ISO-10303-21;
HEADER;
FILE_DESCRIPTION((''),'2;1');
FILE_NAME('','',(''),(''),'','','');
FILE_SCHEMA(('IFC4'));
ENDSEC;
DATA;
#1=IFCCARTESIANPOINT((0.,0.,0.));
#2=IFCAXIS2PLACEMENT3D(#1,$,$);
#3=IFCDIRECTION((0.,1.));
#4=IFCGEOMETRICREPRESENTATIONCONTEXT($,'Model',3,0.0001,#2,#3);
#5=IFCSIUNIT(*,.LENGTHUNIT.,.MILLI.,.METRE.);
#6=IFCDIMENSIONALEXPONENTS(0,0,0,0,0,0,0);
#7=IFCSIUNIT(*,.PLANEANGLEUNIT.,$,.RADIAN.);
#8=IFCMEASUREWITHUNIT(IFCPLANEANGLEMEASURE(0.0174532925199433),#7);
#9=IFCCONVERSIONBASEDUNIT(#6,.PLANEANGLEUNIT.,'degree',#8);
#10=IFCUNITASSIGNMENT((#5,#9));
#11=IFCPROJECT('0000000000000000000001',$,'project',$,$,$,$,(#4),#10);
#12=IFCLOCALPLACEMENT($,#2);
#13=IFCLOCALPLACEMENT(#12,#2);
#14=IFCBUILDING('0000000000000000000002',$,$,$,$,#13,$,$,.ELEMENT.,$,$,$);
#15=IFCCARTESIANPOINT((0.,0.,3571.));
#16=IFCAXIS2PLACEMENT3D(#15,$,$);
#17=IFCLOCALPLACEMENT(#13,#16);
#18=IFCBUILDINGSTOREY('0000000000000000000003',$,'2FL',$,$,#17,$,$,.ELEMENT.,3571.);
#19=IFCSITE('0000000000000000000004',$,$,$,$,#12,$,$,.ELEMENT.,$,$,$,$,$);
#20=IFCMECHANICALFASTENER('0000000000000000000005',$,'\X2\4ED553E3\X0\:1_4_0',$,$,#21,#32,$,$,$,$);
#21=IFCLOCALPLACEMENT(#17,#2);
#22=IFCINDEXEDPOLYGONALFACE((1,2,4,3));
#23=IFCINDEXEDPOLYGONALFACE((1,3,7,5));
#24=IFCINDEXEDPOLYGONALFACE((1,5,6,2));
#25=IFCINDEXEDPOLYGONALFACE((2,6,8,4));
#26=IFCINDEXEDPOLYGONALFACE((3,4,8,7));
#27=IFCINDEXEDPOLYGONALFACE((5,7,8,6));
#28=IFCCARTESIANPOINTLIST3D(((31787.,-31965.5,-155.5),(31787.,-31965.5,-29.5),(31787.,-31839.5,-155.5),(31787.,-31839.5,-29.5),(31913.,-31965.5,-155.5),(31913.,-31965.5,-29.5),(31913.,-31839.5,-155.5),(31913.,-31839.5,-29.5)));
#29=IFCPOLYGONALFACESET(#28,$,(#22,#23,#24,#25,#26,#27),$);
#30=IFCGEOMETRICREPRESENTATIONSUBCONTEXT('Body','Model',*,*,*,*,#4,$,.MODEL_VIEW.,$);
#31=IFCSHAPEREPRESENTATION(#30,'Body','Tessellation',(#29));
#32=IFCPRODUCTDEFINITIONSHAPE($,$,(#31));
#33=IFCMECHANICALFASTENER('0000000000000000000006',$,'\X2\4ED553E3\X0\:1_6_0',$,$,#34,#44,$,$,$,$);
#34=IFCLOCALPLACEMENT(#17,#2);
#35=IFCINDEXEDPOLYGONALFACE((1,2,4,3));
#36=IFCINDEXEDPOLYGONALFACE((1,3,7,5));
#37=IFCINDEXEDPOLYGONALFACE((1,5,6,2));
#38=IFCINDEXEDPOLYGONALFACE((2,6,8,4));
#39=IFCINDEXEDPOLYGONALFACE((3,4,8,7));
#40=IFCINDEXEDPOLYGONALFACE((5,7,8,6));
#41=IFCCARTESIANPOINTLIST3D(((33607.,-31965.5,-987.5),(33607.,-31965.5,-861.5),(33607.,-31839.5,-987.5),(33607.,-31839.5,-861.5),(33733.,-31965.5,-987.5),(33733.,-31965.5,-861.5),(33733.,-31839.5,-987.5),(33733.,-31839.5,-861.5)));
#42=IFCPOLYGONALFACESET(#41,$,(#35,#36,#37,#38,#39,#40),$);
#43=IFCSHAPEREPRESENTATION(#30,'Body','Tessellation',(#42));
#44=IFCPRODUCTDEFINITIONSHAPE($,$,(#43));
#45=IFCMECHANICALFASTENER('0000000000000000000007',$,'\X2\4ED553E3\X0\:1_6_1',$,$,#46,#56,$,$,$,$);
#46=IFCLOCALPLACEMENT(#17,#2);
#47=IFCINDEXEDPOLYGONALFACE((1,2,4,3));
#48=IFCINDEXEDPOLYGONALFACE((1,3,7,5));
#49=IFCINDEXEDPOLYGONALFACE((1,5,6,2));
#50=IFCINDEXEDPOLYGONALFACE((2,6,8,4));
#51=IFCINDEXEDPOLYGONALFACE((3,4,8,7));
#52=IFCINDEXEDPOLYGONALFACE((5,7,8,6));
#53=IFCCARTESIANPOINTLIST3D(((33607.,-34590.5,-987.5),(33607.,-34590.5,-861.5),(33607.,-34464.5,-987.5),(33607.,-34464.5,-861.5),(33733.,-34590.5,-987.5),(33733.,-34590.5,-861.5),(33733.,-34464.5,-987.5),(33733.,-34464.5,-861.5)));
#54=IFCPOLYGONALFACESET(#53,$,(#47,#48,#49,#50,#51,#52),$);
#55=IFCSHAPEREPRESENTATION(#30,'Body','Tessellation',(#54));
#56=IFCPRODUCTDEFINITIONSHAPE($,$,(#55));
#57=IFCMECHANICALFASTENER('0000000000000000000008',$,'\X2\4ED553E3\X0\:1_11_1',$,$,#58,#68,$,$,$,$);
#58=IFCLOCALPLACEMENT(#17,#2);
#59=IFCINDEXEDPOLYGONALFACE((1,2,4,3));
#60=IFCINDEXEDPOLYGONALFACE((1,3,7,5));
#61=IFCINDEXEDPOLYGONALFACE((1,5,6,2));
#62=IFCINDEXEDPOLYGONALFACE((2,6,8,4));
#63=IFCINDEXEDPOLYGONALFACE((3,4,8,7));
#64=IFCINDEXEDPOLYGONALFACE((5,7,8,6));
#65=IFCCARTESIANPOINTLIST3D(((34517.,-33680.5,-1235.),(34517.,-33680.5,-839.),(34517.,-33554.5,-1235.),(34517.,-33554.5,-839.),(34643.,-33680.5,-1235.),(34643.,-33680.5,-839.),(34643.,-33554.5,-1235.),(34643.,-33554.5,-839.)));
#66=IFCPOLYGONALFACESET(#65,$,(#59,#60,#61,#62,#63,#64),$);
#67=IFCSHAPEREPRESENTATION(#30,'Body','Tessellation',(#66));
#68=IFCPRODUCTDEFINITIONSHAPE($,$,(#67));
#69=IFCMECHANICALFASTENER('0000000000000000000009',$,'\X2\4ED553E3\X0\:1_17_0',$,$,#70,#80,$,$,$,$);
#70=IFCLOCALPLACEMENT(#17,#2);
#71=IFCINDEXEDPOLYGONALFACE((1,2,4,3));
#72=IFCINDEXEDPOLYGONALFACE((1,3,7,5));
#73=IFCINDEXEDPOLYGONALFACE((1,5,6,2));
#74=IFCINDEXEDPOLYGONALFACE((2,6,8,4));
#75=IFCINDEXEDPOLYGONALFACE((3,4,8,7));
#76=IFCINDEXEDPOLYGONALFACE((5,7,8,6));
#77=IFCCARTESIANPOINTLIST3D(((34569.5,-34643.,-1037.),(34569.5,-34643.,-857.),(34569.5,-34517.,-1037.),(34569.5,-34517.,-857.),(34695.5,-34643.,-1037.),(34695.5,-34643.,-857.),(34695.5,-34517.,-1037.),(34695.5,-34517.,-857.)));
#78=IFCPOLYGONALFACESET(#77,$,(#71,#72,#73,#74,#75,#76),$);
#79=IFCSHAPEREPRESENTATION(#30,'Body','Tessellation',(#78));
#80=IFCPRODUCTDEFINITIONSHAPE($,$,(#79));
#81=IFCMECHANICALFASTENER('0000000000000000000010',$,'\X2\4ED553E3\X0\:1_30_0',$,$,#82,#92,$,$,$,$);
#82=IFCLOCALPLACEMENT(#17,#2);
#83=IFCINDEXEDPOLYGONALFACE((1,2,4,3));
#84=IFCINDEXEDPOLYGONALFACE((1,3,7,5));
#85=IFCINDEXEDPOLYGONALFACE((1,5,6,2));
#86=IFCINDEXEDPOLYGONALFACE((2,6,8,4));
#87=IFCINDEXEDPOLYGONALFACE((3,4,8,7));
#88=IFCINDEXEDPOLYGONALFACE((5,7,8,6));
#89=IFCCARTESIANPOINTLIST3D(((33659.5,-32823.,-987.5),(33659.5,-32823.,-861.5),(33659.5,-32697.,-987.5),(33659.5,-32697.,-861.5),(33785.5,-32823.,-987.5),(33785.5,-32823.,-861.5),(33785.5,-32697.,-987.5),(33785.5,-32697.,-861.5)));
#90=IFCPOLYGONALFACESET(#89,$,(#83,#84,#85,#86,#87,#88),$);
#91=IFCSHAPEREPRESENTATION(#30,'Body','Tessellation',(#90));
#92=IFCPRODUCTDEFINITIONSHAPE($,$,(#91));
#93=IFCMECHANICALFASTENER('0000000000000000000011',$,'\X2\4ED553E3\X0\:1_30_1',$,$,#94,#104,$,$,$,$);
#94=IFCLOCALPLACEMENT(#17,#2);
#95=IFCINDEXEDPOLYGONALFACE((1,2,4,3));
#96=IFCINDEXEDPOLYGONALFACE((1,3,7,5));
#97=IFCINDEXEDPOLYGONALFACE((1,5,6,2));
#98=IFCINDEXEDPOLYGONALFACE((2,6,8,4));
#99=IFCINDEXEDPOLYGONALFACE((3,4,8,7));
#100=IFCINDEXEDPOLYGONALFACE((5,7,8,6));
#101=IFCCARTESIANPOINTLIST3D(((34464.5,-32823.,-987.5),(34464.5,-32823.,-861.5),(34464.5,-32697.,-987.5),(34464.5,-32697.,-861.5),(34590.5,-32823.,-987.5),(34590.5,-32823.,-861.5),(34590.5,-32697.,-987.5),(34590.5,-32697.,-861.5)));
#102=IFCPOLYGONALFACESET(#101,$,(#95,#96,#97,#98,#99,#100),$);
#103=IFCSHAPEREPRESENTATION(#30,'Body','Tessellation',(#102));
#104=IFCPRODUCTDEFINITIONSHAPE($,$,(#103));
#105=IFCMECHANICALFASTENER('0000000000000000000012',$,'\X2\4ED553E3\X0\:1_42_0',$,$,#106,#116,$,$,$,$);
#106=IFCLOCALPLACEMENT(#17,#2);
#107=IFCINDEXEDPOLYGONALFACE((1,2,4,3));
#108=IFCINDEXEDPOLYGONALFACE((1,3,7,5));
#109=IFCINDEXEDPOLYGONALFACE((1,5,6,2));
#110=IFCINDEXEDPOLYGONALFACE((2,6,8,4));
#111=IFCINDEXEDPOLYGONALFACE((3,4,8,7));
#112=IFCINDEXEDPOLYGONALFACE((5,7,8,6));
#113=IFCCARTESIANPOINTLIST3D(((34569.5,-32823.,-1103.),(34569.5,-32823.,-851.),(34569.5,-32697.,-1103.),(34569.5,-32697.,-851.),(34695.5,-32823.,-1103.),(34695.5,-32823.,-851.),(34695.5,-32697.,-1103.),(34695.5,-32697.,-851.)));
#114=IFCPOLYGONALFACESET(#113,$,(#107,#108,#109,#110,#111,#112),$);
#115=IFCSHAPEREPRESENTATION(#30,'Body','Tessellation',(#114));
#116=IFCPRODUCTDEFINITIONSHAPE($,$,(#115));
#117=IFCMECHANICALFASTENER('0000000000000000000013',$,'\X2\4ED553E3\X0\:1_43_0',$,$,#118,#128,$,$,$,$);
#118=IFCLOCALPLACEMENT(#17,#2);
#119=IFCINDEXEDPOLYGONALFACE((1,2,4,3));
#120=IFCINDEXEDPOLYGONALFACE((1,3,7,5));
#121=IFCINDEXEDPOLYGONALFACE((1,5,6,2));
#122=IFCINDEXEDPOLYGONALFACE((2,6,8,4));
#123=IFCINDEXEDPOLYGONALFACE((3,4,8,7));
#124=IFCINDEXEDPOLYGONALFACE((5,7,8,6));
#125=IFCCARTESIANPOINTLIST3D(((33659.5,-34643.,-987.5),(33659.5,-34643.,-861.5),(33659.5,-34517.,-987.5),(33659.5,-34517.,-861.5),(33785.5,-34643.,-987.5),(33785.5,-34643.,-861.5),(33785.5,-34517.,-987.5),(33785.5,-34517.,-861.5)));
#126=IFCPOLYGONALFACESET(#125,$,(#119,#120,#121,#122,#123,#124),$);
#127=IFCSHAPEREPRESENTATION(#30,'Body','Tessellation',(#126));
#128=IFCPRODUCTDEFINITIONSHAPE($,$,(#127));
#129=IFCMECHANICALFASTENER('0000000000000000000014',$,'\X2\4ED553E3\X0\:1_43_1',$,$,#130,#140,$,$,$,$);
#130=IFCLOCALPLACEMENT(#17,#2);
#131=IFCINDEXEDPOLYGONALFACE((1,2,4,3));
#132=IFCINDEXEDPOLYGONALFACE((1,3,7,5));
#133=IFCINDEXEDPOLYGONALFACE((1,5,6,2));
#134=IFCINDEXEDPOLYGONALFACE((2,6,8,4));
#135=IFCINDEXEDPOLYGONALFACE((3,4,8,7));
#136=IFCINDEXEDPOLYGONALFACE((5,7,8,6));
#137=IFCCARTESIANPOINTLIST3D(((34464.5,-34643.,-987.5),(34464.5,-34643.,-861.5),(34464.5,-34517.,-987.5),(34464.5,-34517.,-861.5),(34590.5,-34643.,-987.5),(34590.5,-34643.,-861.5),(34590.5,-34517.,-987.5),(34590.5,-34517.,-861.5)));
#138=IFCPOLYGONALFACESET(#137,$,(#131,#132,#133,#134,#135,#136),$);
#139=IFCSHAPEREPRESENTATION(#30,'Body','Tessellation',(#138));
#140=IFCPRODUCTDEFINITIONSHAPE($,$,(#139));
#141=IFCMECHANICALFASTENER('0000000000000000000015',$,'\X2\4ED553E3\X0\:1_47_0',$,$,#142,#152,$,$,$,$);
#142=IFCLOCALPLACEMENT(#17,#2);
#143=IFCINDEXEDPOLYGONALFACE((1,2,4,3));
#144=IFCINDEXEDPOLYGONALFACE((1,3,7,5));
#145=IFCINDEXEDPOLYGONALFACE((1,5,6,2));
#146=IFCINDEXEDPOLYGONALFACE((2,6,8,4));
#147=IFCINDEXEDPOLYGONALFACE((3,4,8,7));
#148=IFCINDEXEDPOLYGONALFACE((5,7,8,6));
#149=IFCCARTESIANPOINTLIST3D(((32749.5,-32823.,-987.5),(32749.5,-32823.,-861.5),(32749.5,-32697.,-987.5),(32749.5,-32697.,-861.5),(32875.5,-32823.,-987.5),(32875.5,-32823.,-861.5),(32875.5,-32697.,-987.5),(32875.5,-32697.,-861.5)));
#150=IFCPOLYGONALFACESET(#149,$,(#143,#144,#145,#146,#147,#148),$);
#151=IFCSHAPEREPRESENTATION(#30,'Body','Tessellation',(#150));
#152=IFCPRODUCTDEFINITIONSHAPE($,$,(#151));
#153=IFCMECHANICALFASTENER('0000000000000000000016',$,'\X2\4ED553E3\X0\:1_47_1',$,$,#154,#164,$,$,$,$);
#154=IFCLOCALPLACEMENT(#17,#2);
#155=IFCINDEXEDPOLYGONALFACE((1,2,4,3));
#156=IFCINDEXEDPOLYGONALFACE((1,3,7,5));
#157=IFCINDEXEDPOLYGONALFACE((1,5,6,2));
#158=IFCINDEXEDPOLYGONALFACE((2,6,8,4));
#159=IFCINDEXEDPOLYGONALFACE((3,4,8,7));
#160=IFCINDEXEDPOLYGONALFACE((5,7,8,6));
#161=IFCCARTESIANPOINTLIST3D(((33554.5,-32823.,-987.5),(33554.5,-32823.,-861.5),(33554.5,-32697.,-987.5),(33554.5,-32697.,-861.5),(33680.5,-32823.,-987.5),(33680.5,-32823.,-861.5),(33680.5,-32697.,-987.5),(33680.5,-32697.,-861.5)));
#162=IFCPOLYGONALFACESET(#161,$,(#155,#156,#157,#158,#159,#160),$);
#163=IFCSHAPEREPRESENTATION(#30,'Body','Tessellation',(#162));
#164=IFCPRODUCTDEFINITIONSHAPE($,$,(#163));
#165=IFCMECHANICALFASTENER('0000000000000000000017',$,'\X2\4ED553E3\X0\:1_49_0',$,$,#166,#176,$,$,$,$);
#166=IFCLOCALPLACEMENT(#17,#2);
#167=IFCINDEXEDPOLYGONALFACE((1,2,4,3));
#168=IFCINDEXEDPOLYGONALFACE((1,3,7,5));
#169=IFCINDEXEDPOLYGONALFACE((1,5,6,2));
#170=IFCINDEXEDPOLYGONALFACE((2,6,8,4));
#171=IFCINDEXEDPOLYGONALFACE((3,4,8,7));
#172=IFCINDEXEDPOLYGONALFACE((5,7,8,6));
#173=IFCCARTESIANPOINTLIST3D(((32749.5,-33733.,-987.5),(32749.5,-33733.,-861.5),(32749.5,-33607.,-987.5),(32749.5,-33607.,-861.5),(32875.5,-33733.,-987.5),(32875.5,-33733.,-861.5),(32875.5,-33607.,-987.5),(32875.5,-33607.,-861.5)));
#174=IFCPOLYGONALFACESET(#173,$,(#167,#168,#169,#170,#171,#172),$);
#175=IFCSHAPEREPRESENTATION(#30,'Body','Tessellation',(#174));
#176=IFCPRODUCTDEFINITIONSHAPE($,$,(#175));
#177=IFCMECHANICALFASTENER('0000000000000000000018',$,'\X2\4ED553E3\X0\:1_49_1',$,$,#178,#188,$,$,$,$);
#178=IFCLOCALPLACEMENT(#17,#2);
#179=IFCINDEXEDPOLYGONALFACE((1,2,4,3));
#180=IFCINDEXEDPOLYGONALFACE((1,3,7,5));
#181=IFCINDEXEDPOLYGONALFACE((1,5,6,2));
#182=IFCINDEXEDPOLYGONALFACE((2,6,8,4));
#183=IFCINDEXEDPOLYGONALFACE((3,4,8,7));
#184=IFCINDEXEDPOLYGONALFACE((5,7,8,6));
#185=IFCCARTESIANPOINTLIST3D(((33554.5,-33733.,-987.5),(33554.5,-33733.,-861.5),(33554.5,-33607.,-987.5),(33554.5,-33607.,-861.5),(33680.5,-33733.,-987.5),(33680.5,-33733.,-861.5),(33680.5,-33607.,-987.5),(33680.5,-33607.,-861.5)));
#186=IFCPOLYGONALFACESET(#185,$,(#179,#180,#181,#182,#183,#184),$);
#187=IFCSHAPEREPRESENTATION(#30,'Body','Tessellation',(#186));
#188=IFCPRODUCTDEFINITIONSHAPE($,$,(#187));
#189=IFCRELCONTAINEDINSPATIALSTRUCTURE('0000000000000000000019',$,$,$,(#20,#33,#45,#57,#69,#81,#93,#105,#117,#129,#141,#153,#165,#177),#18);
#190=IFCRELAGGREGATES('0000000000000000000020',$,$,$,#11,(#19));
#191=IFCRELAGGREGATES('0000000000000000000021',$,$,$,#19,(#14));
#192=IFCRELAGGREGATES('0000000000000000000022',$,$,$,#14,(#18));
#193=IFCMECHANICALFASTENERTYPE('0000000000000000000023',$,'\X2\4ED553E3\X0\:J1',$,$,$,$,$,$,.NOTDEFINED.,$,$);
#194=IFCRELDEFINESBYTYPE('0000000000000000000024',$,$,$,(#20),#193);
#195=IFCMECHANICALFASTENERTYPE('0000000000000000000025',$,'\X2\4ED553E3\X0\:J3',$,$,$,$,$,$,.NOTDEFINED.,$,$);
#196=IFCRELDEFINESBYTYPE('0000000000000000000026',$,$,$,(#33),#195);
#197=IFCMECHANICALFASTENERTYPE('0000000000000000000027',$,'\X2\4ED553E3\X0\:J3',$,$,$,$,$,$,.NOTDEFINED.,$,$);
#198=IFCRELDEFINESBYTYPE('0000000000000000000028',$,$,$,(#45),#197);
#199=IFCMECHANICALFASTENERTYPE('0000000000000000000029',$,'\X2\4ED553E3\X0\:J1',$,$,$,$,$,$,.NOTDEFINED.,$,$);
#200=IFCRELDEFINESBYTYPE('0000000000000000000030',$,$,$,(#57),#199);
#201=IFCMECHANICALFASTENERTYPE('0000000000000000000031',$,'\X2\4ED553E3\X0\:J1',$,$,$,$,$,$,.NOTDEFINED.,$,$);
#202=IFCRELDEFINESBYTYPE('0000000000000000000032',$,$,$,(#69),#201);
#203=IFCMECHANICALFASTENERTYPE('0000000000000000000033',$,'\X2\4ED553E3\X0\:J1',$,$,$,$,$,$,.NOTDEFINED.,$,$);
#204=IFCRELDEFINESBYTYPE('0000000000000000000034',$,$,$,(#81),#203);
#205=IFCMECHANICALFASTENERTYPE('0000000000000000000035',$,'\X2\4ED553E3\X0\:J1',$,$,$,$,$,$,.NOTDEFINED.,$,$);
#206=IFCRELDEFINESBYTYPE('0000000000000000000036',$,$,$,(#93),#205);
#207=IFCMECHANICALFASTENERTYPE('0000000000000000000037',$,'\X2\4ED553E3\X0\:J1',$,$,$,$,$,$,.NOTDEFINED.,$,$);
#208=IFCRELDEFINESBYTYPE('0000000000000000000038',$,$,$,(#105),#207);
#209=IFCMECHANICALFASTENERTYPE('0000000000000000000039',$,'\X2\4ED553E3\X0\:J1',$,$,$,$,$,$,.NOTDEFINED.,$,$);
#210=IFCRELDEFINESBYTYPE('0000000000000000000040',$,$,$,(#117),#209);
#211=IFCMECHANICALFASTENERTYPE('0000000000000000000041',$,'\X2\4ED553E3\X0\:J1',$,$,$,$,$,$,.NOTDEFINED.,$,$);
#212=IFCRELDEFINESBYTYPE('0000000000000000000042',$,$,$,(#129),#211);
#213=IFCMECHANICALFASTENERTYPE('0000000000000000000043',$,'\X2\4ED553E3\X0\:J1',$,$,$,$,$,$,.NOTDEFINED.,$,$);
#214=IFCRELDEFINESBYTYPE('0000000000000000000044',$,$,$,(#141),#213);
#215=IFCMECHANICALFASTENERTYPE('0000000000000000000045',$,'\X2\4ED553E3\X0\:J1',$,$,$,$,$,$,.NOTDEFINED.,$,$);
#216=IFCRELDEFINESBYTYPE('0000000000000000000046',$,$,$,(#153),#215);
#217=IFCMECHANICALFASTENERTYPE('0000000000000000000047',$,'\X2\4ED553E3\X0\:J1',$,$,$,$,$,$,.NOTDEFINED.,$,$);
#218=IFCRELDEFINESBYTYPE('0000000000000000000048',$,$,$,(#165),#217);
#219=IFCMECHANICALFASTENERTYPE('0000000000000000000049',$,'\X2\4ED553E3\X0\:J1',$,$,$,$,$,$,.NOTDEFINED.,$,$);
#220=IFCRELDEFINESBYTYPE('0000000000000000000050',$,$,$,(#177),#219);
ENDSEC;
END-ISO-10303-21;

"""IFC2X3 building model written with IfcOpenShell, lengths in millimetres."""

from ifc_helpers import new_model, entity, si_unit, converted_unit, direction, frame, origin, origin_with_axes, origin_2d, place, context, subcontext, project, spatial, rectangle, extrude, type_object, element, save


model = new_model("IFC2X3")

# Units and contexts
model_context = context("Model", 3, precision=0.0001, world=origin(), true_north=direction((0.0, 1.0)))
body_context = subcontext(model_context, "Body", "Model", "MODEL_VIEW")
ifc_project = project(units=[si_unit("LENGTHUNIT", "METRE", prefix="MILLI"), converted_unit("PLANEANGLEUNIT", "degree", entity("IfcPlaneAngleMeasure", 0.0174532925199433), si_unit("PLANEANGLEUNIT", "RADIAN"), dimensions=[0, 0, 0, 0, 0, 0, 0])], contexts=[model_context])

# Site, building, storey
site_placement = place(None, origin())
site = spatial("IfcSite", under=ifc_project, at=site_placement, CompositionType="ELEMENT")
building_placement = place(site_placement, origin())
building = spatial("IfcBuilding", under=site, at=building_placement, CompositionType="ELEMENT")
storey_placement = place(building_placement, frame((0.0, 0.0, 3571.0)))
storey = spatial("IfcBuildingStorey", under=building, at=storey_placement, Name="2FL", CompositionType="ELEMENT", Elevation=3571.0)

# Mechanical fasteners
mechanical_fastener_type_1 = type_object("IfcMechanicalFastenerType", Name="仕口:J1")
mechanical_fastener_1_placement = place(storey_placement, frame((31850.0, -31902.5, -155.5)))
element("IfcMechanicalFastener", 1, at=mechanical_fastener_1_placement, inside=storey, type_object=mechanical_fastener_type_1, Name="仕口:1_4_0", context=body_context, shape_type="SweptSolid", body=[
    extrude(rectangle(XDim=126.0, YDim=126.0, at=origin_2d()), origin_with_axes(), (0.0, 0.0, 1.0), 126.0),
])
mechanical_fastener_type_2 = type_object("IfcMechanicalFastenerType", Name="仕口:J3")
mechanical_fastener_2_placement = place(storey_placement, frame((33670.0, -31902.5, -987.5)))
element("IfcMechanicalFastener", 2, at=mechanical_fastener_2_placement, inside=storey, type_object=mechanical_fastener_type_2, Name="仕口:1_6_0", context=body_context, shape_type="SweptSolid", body=[
    extrude(rectangle(XDim=126.0, YDim=126.0, at=origin_2d()), origin_with_axes(), (0.0, 0.0, 1.0), 126.0),
])
mechanical_fastener_type_3 = type_object("IfcMechanicalFastenerType", Name="仕口:J3")
mechanical_fastener_3_placement = place(storey_placement, frame((33670.0, -34527.5, -987.5)))
element("IfcMechanicalFastener", 3, at=mechanical_fastener_3_placement, inside=storey, type_object=mechanical_fastener_type_3, Name="仕口:1_6_1", context=body_context, shape_type="SweptSolid", body=[
    extrude(rectangle(XDim=126.0, YDim=126.0, at=origin_2d()), origin_with_axes(), (0.0, 0.0, 1.0), 126.0),
])
mechanical_fastener_type_4 = type_object("IfcMechanicalFastenerType", Name="仕口:J1")
mechanical_fastener_4_placement = place(storey_placement, frame((34580.0, -33617.5, -1235.0)))
element("IfcMechanicalFastener", 4, at=mechanical_fastener_4_placement, inside=storey, type_object=mechanical_fastener_type_4, Name="仕口:1_11_1", context=body_context, shape_type="SweptSolid", body=[
    extrude(rectangle(XDim=126.0, YDim=126.0, at=origin_2d()), origin_with_axes(), (0.0, 0.0, 1.0), 396.0),
])
mechanical_fastener_type_5 = type_object("IfcMechanicalFastenerType", Name="仕口:J1")
mechanical_fastener_5_placement = place(storey_placement, frame((34632.5, -34580.0, -1037.0)))
element("IfcMechanicalFastener", 5, at=mechanical_fastener_5_placement, inside=storey, type_object=mechanical_fastener_type_5, Name="仕口:1_17_0", context=body_context, shape_type="SweptSolid", body=[
    extrude(rectangle(XDim=126.0, YDim=126.0, at=origin_2d()), origin_with_axes(), (0.0, 0.0, 1.0), 180.0),
])
mechanical_fastener_type_6 = type_object("IfcMechanicalFastenerType", Name="仕口:J1")
mechanical_fastener_6_placement = place(storey_placement, frame((33722.5, -32760.0, -987.5)))
element("IfcMechanicalFastener", 6, at=mechanical_fastener_6_placement, inside=storey, type_object=mechanical_fastener_type_6, Name="仕口:1_30_0", context=body_context, shape_type="SweptSolid", body=[
    extrude(rectangle(XDim=126.0, YDim=126.0, at=origin_2d()), origin_with_axes(), (0.0, 0.0, 1.0), 126.0),
])
mechanical_fastener_type_7 = type_object("IfcMechanicalFastenerType", Name="仕口:J1")
mechanical_fastener_7_placement = place(storey_placement, frame((34527.5, -32760.0, -987.5)))
element("IfcMechanicalFastener", 7, at=mechanical_fastener_7_placement, inside=storey, type_object=mechanical_fastener_type_7, Name="仕口:1_30_1", context=body_context, shape_type="SweptSolid", body=[
    extrude(rectangle(XDim=126.0, YDim=126.0, at=origin_2d()), origin_with_axes(), (0.0, 0.0, 1.0), 126.0),
])
mechanical_fastener_type_8 = type_object("IfcMechanicalFastenerType", Name="仕口:J1")
mechanical_fastener_8_placement = place(storey_placement, frame((34632.5, -32760.0, -1103.0)))
element("IfcMechanicalFastener", 8, at=mechanical_fastener_8_placement, inside=storey, type_object=mechanical_fastener_type_8, Name="仕口:1_42_0", context=body_context, shape_type="SweptSolid", body=[
    extrude(rectangle(XDim=126.0, YDim=126.0, at=origin_2d()), origin_with_axes(), (0.0, 0.0, 1.0), 252.0),
])
mechanical_fastener_type_9 = type_object("IfcMechanicalFastenerType", Name="仕口:J1")
mechanical_fastener_9_placement = place(storey_placement, frame((33722.5, -34580.0, -987.5)))
element("IfcMechanicalFastener", 9, at=mechanical_fastener_9_placement, inside=storey, type_object=mechanical_fastener_type_9, Name="仕口:1_43_0", context=body_context, shape_type="SweptSolid", body=[
    extrude(rectangle(XDim=126.0, YDim=126.0, at=origin_2d()), origin_with_axes(), (0.0, 0.0, 1.0), 126.0),
])
mechanical_fastener_type_10 = type_object("IfcMechanicalFastenerType", Name="仕口:J1")
mechanical_fastener_10_placement = place(storey_placement, frame((34527.5, -34580.0, -987.5)))
element("IfcMechanicalFastener", 10, at=mechanical_fastener_10_placement, inside=storey, type_object=mechanical_fastener_type_10, Name="仕口:1_43_1", context=body_context, shape_type="SweptSolid", body=[
    extrude(rectangle(XDim=126.0, YDim=126.0, at=origin_2d()), origin_with_axes(), (0.0, 0.0, 1.0), 126.0),
])
mechanical_fastener_type_11 = type_object("IfcMechanicalFastenerType", Name="仕口:J1")
mechanical_fastener_11_placement = place(storey_placement, frame((32812.5, -32760.0, -987.5)))
element("IfcMechanicalFastener", 11, at=mechanical_fastener_11_placement, inside=storey, type_object=mechanical_fastener_type_11, Name="仕口:1_47_0", context=body_context, shape_type="SweptSolid", body=[
    extrude(rectangle(XDim=126.0, YDim=126.0, at=origin_2d()), origin_with_axes(), (0.0, 0.0, 1.0), 126.0),
])
mechanical_fastener_type_12 = type_object("IfcMechanicalFastenerType", Name="仕口:J1")
mechanical_fastener_12_placement = place(storey_placement, frame((33617.5, -32760.0, -987.5)))
element("IfcMechanicalFastener", 12, at=mechanical_fastener_12_placement, inside=storey, type_object=mechanical_fastener_type_12, Name="仕口:1_47_1", context=body_context, shape_type="SweptSolid", body=[
    extrude(rectangle(XDim=126.0, YDim=126.0, at=origin_2d()), origin_with_axes(), (0.0, 0.0, 1.0), 126.0),
])
mechanical_fastener_type_13 = type_object("IfcMechanicalFastenerType", Name="仕口:J1")
mechanical_fastener_13_placement = place(storey_placement, frame((32812.5, -33670.0, -987.5)))
element("IfcMechanicalFastener", 13, at=mechanical_fastener_13_placement, inside=storey, type_object=mechanical_fastener_type_13, Name="仕口:1_49_0", context=body_context, shape_type="SweptSolid", body=[
    extrude(rectangle(XDim=126.0, YDim=126.0, at=origin_2d()), origin_with_axes(), (0.0, 0.0, 1.0), 126.0),
])
mechanical_fastener_type_14 = type_object("IfcMechanicalFastenerType", Name="仕口:J1")
mechanical_fastener_14_placement = place(storey_placement, frame((33617.5, -33670.0, -987.5)))
element("IfcMechanicalFastener", 14, at=mechanical_fastener_14_placement, inside=storey, type_object=mechanical_fastener_type_14, Name="仕口:1_49_1", context=body_context, shape_type="SweptSolid", body=[
    extrude(rectangle(XDim=126.0, YDim=126.0, at=origin_2d()), origin_with_axes(), (0.0, 0.0, 1.0), 126.0),
])

save(model, "model.ifc")
